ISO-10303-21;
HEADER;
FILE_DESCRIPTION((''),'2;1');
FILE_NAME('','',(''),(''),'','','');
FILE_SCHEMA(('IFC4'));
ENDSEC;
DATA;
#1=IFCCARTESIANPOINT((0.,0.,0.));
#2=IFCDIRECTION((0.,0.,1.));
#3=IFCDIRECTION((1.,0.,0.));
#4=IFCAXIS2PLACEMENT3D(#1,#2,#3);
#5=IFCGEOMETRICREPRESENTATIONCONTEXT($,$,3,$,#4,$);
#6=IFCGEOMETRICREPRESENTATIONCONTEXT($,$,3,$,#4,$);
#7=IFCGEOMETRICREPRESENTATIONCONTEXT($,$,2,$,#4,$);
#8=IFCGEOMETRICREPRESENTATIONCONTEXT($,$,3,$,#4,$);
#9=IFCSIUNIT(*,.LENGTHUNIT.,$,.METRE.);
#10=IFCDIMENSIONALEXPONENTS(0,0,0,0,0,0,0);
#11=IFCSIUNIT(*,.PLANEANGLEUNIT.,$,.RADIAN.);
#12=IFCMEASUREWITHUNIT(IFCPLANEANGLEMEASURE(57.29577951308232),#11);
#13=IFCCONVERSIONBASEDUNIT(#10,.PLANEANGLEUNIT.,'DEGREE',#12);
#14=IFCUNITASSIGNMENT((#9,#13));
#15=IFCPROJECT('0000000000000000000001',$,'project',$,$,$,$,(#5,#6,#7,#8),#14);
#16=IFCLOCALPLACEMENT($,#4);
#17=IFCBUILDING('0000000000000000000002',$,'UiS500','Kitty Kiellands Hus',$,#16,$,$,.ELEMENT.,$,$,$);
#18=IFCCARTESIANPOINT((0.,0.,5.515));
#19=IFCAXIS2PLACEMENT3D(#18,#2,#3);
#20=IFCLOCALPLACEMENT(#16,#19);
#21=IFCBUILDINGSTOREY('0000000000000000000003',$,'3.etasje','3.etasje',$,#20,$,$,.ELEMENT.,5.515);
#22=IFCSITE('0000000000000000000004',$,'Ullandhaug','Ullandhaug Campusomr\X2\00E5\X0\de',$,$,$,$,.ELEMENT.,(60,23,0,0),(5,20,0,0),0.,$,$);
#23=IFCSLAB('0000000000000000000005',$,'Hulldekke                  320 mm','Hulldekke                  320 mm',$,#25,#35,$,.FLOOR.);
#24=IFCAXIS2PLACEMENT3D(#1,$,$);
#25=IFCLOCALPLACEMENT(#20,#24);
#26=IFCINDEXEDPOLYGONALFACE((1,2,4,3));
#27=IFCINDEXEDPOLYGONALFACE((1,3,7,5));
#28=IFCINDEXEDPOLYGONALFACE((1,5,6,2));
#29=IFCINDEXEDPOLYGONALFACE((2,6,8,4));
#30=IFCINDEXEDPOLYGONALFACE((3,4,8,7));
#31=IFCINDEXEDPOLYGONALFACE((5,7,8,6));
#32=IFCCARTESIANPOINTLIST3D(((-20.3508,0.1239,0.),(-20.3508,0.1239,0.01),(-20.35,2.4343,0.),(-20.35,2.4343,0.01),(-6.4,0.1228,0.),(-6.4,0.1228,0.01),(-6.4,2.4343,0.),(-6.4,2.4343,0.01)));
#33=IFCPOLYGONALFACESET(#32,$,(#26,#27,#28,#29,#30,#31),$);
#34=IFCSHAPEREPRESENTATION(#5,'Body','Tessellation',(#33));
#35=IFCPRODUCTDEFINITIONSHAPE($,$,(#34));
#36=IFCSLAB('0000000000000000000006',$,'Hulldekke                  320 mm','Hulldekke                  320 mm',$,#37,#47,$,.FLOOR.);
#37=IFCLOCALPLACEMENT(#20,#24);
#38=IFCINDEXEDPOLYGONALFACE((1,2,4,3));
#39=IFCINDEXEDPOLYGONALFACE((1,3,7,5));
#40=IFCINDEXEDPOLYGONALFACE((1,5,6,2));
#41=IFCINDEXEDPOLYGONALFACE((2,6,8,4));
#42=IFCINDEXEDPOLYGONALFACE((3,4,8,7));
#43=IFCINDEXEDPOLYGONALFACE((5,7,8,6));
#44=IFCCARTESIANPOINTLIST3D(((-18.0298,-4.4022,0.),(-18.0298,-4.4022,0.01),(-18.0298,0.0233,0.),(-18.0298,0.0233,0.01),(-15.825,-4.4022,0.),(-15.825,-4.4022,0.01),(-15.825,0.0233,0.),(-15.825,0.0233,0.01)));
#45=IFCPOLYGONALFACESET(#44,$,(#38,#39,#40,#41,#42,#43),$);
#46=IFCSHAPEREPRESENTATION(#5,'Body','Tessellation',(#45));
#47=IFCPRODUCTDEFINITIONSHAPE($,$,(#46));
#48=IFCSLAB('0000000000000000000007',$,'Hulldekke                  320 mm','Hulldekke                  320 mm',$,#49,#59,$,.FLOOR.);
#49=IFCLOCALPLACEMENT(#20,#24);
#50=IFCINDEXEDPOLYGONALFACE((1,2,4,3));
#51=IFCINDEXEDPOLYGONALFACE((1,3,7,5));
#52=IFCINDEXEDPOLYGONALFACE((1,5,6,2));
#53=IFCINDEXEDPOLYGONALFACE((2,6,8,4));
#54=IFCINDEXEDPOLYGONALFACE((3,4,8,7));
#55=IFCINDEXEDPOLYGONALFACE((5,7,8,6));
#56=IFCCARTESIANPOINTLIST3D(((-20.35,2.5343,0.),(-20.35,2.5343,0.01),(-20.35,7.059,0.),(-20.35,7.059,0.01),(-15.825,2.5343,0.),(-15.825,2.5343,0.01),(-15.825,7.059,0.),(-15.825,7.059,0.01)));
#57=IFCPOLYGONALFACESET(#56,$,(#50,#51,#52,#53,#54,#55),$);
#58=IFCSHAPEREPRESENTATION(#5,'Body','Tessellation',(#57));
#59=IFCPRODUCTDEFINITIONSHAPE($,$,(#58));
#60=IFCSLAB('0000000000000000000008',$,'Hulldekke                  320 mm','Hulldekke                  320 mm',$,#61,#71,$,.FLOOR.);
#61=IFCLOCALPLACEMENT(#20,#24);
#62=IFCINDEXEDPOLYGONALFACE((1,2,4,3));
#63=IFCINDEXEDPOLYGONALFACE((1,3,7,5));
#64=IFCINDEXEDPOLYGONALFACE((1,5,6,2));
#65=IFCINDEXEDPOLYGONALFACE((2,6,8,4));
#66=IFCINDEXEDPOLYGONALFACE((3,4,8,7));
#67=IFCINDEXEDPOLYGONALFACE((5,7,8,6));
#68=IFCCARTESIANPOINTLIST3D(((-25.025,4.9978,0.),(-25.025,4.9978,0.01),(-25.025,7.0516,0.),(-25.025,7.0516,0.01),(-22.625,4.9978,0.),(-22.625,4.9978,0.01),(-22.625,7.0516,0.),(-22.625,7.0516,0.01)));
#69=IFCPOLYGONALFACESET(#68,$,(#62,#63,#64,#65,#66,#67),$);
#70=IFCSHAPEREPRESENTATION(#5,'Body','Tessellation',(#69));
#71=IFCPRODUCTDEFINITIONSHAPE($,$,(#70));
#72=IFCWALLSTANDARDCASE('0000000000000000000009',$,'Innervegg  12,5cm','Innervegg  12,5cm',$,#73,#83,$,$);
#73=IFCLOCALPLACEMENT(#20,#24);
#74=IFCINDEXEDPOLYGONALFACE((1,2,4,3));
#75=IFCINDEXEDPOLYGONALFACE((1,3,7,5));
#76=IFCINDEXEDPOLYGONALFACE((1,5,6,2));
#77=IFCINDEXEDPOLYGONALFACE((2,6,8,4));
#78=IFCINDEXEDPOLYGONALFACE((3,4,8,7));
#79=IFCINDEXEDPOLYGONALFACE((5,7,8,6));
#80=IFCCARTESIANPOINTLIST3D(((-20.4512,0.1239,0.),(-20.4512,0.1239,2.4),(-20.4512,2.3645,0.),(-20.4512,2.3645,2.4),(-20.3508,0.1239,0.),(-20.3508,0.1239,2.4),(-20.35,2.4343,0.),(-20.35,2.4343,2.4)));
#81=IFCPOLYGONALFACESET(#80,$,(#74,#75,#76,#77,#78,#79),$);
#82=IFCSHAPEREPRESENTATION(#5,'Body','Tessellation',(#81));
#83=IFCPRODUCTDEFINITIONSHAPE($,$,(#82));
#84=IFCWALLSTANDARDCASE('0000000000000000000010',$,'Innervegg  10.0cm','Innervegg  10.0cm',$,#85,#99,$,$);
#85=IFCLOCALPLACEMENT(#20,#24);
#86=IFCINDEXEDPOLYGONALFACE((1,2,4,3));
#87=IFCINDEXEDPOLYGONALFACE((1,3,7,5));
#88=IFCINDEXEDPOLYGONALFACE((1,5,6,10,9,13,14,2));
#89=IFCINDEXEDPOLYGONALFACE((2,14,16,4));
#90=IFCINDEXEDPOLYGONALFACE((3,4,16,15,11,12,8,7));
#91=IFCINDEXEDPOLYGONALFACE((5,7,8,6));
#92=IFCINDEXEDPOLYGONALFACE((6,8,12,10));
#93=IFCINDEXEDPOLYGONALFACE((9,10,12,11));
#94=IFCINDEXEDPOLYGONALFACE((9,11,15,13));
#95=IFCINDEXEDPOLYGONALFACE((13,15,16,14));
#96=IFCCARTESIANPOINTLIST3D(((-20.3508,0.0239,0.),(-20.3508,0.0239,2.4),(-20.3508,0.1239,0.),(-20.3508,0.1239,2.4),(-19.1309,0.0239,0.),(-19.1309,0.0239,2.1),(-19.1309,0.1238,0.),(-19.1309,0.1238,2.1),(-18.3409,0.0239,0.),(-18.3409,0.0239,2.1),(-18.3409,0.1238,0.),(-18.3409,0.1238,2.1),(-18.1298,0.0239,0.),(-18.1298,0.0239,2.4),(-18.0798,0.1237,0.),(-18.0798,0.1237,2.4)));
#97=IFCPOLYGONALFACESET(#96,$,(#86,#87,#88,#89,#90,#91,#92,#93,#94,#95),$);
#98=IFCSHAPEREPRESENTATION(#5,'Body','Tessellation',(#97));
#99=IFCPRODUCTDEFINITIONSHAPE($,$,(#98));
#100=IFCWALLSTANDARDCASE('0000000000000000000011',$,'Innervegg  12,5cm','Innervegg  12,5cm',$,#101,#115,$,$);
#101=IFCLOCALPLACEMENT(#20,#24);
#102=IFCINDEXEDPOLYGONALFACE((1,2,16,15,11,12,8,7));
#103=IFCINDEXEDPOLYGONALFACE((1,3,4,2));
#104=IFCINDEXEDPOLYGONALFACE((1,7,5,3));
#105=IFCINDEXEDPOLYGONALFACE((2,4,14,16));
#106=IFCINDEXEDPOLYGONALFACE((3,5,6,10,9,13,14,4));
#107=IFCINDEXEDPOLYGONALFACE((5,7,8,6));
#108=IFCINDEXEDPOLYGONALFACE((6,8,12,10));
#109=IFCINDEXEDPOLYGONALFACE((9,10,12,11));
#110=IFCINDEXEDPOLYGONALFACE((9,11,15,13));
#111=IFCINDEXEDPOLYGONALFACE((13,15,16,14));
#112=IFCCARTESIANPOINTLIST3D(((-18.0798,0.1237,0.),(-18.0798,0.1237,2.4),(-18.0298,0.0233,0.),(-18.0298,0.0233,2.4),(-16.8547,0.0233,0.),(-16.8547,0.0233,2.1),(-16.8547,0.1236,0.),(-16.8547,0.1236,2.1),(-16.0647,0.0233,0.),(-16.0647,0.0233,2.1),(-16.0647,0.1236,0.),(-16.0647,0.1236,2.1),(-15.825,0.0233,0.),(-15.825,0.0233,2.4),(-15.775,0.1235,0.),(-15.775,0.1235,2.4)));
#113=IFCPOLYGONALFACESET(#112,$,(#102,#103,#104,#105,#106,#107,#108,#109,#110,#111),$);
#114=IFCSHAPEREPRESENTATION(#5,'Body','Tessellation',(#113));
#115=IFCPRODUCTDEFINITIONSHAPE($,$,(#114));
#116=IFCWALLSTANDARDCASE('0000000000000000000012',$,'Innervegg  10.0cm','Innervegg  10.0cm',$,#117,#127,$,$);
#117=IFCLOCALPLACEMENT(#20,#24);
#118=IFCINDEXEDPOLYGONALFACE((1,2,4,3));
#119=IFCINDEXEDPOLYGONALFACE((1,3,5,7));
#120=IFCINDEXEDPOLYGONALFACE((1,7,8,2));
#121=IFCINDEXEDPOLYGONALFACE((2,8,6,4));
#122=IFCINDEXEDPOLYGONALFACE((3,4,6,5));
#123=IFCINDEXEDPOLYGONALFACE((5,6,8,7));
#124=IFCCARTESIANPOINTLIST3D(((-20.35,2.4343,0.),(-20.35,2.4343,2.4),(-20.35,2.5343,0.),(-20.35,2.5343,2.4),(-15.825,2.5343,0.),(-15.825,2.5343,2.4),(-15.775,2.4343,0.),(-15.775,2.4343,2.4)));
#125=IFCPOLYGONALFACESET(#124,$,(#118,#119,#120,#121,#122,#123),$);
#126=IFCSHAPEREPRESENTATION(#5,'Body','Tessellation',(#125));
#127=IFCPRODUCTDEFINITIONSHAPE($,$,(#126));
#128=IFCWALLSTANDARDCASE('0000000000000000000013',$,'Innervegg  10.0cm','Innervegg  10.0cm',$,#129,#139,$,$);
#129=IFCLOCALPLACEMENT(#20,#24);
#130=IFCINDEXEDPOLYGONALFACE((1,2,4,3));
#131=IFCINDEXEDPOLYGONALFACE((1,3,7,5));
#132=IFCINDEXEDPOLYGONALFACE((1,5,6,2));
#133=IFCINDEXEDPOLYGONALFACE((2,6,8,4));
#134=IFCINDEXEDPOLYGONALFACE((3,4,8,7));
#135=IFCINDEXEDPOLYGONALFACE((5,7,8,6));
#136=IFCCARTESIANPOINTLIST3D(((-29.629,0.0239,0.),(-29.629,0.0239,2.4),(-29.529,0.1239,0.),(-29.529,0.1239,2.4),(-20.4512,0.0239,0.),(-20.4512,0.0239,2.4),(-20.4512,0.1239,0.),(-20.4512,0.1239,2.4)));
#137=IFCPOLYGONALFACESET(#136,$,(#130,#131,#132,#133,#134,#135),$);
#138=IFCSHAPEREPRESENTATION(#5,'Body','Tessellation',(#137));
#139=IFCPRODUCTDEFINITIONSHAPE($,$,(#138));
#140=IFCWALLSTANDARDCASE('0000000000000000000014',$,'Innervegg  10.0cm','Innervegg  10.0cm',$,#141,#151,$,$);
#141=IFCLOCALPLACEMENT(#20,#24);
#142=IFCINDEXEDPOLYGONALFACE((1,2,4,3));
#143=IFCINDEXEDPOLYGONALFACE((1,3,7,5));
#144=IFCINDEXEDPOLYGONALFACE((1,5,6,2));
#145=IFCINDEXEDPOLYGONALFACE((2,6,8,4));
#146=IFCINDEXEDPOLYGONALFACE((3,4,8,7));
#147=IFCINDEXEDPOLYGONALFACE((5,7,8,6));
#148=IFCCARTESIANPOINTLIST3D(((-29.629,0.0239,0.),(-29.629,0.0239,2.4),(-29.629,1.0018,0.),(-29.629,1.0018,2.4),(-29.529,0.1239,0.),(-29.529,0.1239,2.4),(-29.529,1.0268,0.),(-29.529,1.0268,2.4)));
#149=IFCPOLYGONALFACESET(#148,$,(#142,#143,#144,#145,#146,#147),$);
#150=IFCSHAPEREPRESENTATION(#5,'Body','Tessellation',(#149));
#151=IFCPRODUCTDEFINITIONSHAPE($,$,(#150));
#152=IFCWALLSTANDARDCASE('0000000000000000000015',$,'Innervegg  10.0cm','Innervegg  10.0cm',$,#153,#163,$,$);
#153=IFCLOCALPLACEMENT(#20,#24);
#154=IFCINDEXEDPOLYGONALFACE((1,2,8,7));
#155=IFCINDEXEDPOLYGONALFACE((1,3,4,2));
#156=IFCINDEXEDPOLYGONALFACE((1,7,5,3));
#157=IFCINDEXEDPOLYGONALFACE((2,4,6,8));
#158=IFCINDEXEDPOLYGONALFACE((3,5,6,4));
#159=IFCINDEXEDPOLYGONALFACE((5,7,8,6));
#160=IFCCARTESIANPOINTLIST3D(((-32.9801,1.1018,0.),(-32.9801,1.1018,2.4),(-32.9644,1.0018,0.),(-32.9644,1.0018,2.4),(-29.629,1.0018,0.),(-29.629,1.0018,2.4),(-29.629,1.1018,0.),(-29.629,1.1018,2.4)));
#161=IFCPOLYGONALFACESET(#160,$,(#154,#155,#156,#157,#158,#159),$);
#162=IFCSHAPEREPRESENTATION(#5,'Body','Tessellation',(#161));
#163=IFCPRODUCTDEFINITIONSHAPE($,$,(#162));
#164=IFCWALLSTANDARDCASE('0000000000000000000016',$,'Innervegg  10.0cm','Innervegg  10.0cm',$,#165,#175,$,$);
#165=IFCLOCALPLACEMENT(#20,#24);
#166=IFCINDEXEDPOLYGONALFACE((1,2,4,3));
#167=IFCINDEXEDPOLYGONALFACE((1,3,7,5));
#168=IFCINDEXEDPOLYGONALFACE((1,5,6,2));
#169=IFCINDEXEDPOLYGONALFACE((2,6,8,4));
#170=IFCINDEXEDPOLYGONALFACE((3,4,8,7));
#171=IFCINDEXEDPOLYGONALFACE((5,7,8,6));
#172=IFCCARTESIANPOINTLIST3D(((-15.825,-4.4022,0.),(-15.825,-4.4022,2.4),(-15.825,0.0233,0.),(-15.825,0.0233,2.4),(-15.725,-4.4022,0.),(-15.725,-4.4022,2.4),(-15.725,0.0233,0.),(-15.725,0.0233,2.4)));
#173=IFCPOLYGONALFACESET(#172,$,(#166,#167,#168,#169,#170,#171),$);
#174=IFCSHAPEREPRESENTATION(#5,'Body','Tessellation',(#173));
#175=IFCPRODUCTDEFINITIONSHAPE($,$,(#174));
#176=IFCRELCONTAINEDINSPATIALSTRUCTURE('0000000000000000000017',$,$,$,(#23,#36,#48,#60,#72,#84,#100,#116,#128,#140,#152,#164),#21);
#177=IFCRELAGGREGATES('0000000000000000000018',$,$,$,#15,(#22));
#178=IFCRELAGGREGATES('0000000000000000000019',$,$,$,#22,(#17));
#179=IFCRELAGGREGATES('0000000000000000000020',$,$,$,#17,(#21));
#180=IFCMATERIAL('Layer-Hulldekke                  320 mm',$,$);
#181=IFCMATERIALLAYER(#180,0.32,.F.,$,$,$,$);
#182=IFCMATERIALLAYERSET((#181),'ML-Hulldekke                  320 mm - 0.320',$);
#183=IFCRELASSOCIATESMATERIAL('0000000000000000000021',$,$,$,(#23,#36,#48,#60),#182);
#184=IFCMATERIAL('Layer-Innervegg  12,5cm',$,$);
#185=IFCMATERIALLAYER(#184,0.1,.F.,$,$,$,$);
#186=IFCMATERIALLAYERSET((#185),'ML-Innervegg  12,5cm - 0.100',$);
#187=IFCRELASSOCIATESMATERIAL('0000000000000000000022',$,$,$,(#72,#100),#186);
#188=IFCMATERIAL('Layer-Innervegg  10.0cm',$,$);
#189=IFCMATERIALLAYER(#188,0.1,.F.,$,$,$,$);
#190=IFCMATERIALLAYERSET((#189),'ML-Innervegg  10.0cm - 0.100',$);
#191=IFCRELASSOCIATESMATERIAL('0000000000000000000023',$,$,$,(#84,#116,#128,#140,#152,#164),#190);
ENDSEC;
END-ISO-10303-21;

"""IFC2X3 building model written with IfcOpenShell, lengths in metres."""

from ifc_helpers import new_model, entity, si_unit, converted_unit, frame, origin_with_axes, place, context, project, spatial, polyline, outline, extrude, material, layer, layer_set, layer_usage, element, save


model = new_model("IFC2X3")

# Units and contexts
context_of_model_1 = context(None, 3, world=origin_with_axes())
context_of_model_2 = context(None, 3, world=origin_with_axes())
context_of_model_3 = context(None, 2, world=origin_with_axes())
context_of_model_4 = context(None, 3, world=origin_with_axes())
ifc_project = project(units=[si_unit("LENGTHUNIT", "METRE"), converted_unit("PLANEANGLEUNIT", "DEGREE", entity("IfcPlaneAngleMeasure", 57.29577951308232), si_unit("PLANEANGLEUNIT", "RADIAN"), dimensions=[0, 0, 0, 0, 0, 0, 0])], contexts=[context_of_model_1, context_of_model_2, context_of_model_3, context_of_model_4])

# Site, building, storey
site = spatial("IfcSite", under=ifc_project, Name="Ullandhaug", Description="Ullandhaug Campusområde", CompositionType="ELEMENT", RefLatitude=(60, 23, 0, 0), RefLongitude=(5, 20, 0, 0), RefElevation=0.0)
building_placement = place(None, origin_with_axes())
building = spatial("IfcBuilding", under=site, at=building_placement, Name="UiS500", Description="Kitty Kiellands Hus", CompositionType="ELEMENT")
storey_placement = place(building_placement, frame((0.0, 0.0, 5.515), z_axis=(0.0, 0.0, 1.0), x_axis=(1.0, 0.0, 0.0)))
storey = spatial("IfcBuildingStorey", under=building, at=storey_placement, Name="3.etasje", Description="3.etasje", CompositionType="ELEMENT", Elevation=5.515)

# Slabs
ifc_material_1 = material(Name="Layer-Hulldekke                  320 mm")
ifc_layer_1 = layer(ifc_material_1, 0.32, ventilated=False)
ifc_layer_set_1 = layer_set([ifc_layer_1], Name="ML-Hulldekke                  320 mm - 0.320")
ifc_layer_usage_1 = layer_usage(ifc_layer_set_1, "AXIS2", "POSITIVE", 0.0)
slab_1_placement = place(storey_placement, frame((-20.35, 2.4343, 0.0), z_axis=(0.0, 0.0, 1.0), x_axis=(1.0, 0.0, 0.0)))
element("IfcSlab", 1, at=slab_1_placement, inside=storey, material=ifc_layer_usage_1, Name="Hulldekke                  320 mm", Description="Hulldekke                  320 mm", PredefinedType="FLOOR", context=context_of_model_1, shape_type="SweptSolid", body=[
    extrude(outline(polyline([(0.0, 0.0), (2.3104, 0.0), (2.3065, 13.9508), (-0.005, 13.95), (0.0, 0.0)])), frame((0.0, 0.0, 0.0), z_axis=(0.0, 0.0, 1.0), x_axis=(-0.000362, -1.0, 0.0)), (0.0, 0.0, 1.0), 0.01),
])
slab_2_placement = place(storey_placement, frame((-15.825, 0.0233, 0.0), z_axis=(0.0, 0.0, 1.0), x_axis=(1.0, 0.0, 0.0)))
element("IfcSlab", 2, at=slab_2_placement, inside=storey, material=ifc_layer_usage_1, Name="Hulldekke                  320 mm", Description="Hulldekke                  320 mm", PredefinedType="FLOOR", context=context_of_model_1, shape_type="SweptSolid", body=[
    extrude(outline(polyline([(0.0, 0.0), (2.2048, 0.0), (2.2048, 4.4256), (0.0, 4.4256), (0.0, 0.0)])), frame((0.0, 0.0, 0.0), z_axis=(0.0, 0.0, 1.0), x_axis=(-1.0, 0.0, 0.0)), (0.0, 0.0, 1.0), 0.01),
])
slab_3_placement = place(storey_placement, frame((-20.35, 7.059, 0.0), z_axis=(0.0, 0.0, 1.0), x_axis=(1.0, 0.0, 0.0)))
element("IfcSlab", 3, at=slab_3_placement, inside=storey, material=ifc_layer_usage_1, Name="Hulldekke                  320 mm", Description="Hulldekke                  320 mm", PredefinedType="FLOOR", context=context_of_model_1, shape_type="SweptSolid", body=[
    extrude(outline(polyline([(0.0, 0.0), (4.5247, 0.0), (4.5247, 4.525), (0.0, 4.525), (0.0, 0.0)])), frame((0.0, 0.0, 0.0), z_axis=(0.0, 0.0, 1.0), x_axis=(0.0, -1.0, 0.0)), (0.0, 0.0, 1.0), 0.01),
])
slab_4_placement = place(storey_placement, frame((-25.025, 4.9978, 0.0), z_axis=(0.0, 0.0, 1.0), x_axis=(1.0, 0.0, 0.0)))
element("IfcSlab", 4, at=slab_4_placement, inside=storey, material=ifc_layer_usage_1, Name="Hulldekke                  320 mm", Description="Hulldekke                  320 mm", PredefinedType="FLOOR", context=context_of_model_1, shape_type="SweptSolid", body=[
    extrude(outline(polyline([(0.0, 0.0), (2.4, 0.0), (2.4, 2.0539), (0.0, 2.0539), (0.0, 0.0)])), origin_with_axes(), (0.0, 0.0, 1.0), 0.01),
])

# Wall
ifc_material_2 = material(Name="Layer-Innervegg  12,5cm")
ifc_layer_2 = layer(ifc_material_2, 0.1, ventilated=False)
ifc_layer_set_2 = layer_set([ifc_layer_2], Name="ML-Innervegg  12,5cm - 0.100")
ifc_layer_usage_2 = layer_usage(ifc_layer_set_2, "AXIS2", "POSITIVE", 0.0)
wall_1_placement = place(storey_placement, frame((-20.4512, 2.3645, 0.0), z_axis=(0.0, 0.0, 1.0), x_axis=(0.0, -1.0, 0.0)))
element("IfcWallStandardCase", 5, at=wall_1_placement, inside=storey, material=ifc_layer_usage_2, Name="Innervegg  12,5cm", Description="Innervegg  12,5cm", context=context_of_model_1, shape_type="SweptSolid", body=[
    extrude(outline(polyline([(0.0, 0.0), (2.2405, 0.0), (2.2405, 0.1004), (-0.0698, 0.1012), (0.0, 0.0)])), frame((0.0, 0.0, 0.0), z_axis=(0.0, 0.0, 1.0), x_axis=(1.0, 0.0, 0.0)), (0.0, 0.0, 1.0), 2.4),
])

# Walls, openings
ifc_material_3 = material(Name="Layer-Innervegg  10.0cm")
ifc_layer_3 = layer(ifc_material_3, 0.1, ventilated=False)
ifc_layer_set_3 = layer_set([ifc_layer_3], Name="ML-Innervegg  10.0cm - 0.100")
ifc_layer_usage_3 = layer_usage(ifc_layer_set_3, "AXIS2", "POSITIVE", 0.0)
wall_2_placement = place(storey_placement, frame((-20.3508, 0.0239, 0.0), z_axis=(0.0, 0.0, 1.0), x_axis=(1.0, 0.0, 0.0)))
wall_2 = element("IfcWallStandardCase", 6, at=wall_2_placement, inside=storey, material=ifc_layer_usage_3, Name="Innervegg  10.0cm", Description="Innervegg  10.0cm", context=context_of_model_1, shape_type="SweptSolid", body=[
    extrude(outline(polyline([(0.0, 0.0), (2.2211, 0.0), (2.2711, 0.0998), (0.0, 0.1), (0.0, 0.0)])), origin_with_axes(), (0.0, 0.0, 1.0), 2.4),
])
opening_1_placement = place(wall_2_placement, frame((1.22, 0.0999, 0.0), z_axis=(0.0, 0.0, 1.0), x_axis=(1.0, 0.0, 0.0)))
element("IfcOpeningElement", 7, at=opening_1_placement, cuts=wall_2, context=context_of_model_1, shape_type="SweptSolid", body=[
    extrude(outline(polyline([(0.0, 0.0), (2.1, 0.0), (2.1, 0.79), (0.0, 0.79), (0.0, 0.0)])), frame((0.0, 0.0, 0.0), z_axis=(0.000083, 1.0, 0.0), x_axis=(0.0, 0.0, 1.0)), (0.0, 0.000083, -1.0), 0.1),
])
wall_3_placement = place(storey_placement, frame((-18.0298, 0.0233, 0.0), z_axis=(0.0, 0.0, 1.0), x_axis=(1.0, 0.0, 0.0)))
wall_3 = element("IfcWallStandardCase", 8, at=wall_3_placement, inside=storey, material=ifc_layer_usage_2, Name="Innervegg  12,5cm", Description="Innervegg  12,5cm", context=context_of_model_1, shape_type="SweptSolid", body=[
    extrude(outline(polyline([(0.0, 0.0), (2.2048, 0.0), (2.2548, 0.1002), (-0.05, 0.1004), (0.0, 0.0)])), origin_with_axes(), (0.0, 0.0, 1.0), 2.4),
])
opening_2_placement = place(wall_3_placement, frame((1.1751, 0.1003, 0.0), z_axis=(0.0, 0.0, 1.0), x_axis=(1.0, 0.0, 0.0)))
element("IfcOpeningElement", 9, at=opening_2_placement, cuts=wall_3, context=context_of_model_1, shape_type="SweptSolid", body=[
    extrude(outline(polyline([(0.0, 0.0), (2.1, 0.0), (2.1, 0.79), (0.0, 0.79), (0.0, 0.0)])), frame((0.0, 0.0, 0.0), z_axis=(0.000083, 1.0, 0.0), x_axis=(0.0, 0.0, 1.0)), (0.0, 0.000083, -1.0), 0.1003),
])

# Walls
wall_4_placement = place(storey_placement, frame((-15.825, 2.5343, 0.0), z_axis=(0.0, 0.0, 1.0), x_axis=(-1.0, 0.0, 0.0)))
element("IfcWallStandardCase", 10, at=wall_4_placement, inside=storey, material=ifc_layer_usage_3, Name="Innervegg  10.0cm", Description="Innervegg  10.0cm", context=context_of_model_1, shape_type="SweptSolid", body=[
    extrude(outline(polyline([(0.0, 0.0), (4.525, 0.0), (4.525, 0.1), (-0.05, 0.1), (0.0, 0.0)])), frame((0.0, 0.0, 0.0), z_axis=(0.0, 0.0, 1.0), x_axis=(1.0, 0.0, 0.0)), (0.0, 0.0, 1.0), 2.4),
])
wall_5_placement = place(storey_placement, frame((-20.4512, 0.1239, 0.0), z_axis=(0.0, 0.0, 1.0), x_axis=(-1.0, 0.0, 0.0)))
element("IfcWallStandardCase", 11, at=wall_5_placement, inside=storey, material=ifc_layer_usage_3, Name="Innervegg  10.0cm", Description="Innervegg  10.0cm", context=context_of_model_1, shape_type="SweptSolid", body=[
    extrude(outline(polyline([(0.0, 0.0), (9.0777, 0.0), (9.1777, 0.1), (0.0, 0.1), (0.0, 0.0)])), frame((0.0, 0.0, 0.0), z_axis=(0.0, 0.0, 1.0), x_axis=(1.0, 0.0, 0.0)), (0.0, 0.0, 1.0), 2.4),
])
wall_6_placement = place(storey_placement, frame((-29.529, 0.1239, 0.0), z_axis=(0.0, 0.0, 1.0), x_axis=(0.0, 1.0, 0.0)))
element("IfcWallStandardCase", 12, at=wall_6_placement, inside=storey, material=ifc_layer_usage_3, Name="Innervegg  10.0cm", Description="Innervegg  10.0cm", context=context_of_model_1, shape_type="SweptSolid", body=[
    extrude(outline(polyline([(0.0, 0.0), (0.9029, 0.0), (0.8779, 0.1), (-0.1, 0.1), (0.0, 0.0)])), frame((0.0, 0.0, 0.0), z_axis=(0.0, 0.0, 1.0), x_axis=(1.0, 0.0, 0.0)), (0.0, 0.0, 1.0), 2.4),
])
wall_7_placement = place(storey_placement, frame((-29.629, 1.1018, 0.0), z_axis=(0.0, 0.0, 1.0), x_axis=(-1.0, 0.0, 0.0)))
element("IfcWallStandardCase", 13, at=wall_7_placement, inside=storey, material=ifc_layer_usage_3, Name="Innervegg  10.0cm", Description="Innervegg  10.0cm", context=context_of_model_1, shape_type="SweptSolid", body=[
    extrude(outline(polyline([(0.0, 0.0), (3.3511, 0.0), (3.3354, 0.1), (0.0, 0.1), (0.0, 0.0)])), frame((0.0, 0.0, 0.0), z_axis=(0.0, 0.0, 1.0), x_axis=(1.0, 0.0, 0.0)), (0.0, 0.0, 1.0), 2.4),
])
wall_8_placement = place(storey_placement, frame((-15.825, 0.0233, 0.0), z_axis=(0.0, 0.0, 1.0), x_axis=(0.0, -1.0, 0.0)))
element("IfcWallStandardCase", 14, at=wall_8_placement, inside=storey, material=ifc_layer_usage_3, Name="Innervegg  10.0cm", Description="Innervegg  10.0cm", context=context_of_model_1, shape_type="SweptSolid", body=[
    extrude(outline(polyline([(0.0, 0.0), (4.4256, 0.0), (4.4256, 0.1), (0.0, 0.1), (0.0, 0.0)])), frame((0.0, 0.0, 0.0), z_axis=(0.0, 0.0, 1.0), x_axis=(1.0, 0.0, 0.0)), (0.0, 0.0, 1.0), 2.4),
])

save(model, "model.ifc")
